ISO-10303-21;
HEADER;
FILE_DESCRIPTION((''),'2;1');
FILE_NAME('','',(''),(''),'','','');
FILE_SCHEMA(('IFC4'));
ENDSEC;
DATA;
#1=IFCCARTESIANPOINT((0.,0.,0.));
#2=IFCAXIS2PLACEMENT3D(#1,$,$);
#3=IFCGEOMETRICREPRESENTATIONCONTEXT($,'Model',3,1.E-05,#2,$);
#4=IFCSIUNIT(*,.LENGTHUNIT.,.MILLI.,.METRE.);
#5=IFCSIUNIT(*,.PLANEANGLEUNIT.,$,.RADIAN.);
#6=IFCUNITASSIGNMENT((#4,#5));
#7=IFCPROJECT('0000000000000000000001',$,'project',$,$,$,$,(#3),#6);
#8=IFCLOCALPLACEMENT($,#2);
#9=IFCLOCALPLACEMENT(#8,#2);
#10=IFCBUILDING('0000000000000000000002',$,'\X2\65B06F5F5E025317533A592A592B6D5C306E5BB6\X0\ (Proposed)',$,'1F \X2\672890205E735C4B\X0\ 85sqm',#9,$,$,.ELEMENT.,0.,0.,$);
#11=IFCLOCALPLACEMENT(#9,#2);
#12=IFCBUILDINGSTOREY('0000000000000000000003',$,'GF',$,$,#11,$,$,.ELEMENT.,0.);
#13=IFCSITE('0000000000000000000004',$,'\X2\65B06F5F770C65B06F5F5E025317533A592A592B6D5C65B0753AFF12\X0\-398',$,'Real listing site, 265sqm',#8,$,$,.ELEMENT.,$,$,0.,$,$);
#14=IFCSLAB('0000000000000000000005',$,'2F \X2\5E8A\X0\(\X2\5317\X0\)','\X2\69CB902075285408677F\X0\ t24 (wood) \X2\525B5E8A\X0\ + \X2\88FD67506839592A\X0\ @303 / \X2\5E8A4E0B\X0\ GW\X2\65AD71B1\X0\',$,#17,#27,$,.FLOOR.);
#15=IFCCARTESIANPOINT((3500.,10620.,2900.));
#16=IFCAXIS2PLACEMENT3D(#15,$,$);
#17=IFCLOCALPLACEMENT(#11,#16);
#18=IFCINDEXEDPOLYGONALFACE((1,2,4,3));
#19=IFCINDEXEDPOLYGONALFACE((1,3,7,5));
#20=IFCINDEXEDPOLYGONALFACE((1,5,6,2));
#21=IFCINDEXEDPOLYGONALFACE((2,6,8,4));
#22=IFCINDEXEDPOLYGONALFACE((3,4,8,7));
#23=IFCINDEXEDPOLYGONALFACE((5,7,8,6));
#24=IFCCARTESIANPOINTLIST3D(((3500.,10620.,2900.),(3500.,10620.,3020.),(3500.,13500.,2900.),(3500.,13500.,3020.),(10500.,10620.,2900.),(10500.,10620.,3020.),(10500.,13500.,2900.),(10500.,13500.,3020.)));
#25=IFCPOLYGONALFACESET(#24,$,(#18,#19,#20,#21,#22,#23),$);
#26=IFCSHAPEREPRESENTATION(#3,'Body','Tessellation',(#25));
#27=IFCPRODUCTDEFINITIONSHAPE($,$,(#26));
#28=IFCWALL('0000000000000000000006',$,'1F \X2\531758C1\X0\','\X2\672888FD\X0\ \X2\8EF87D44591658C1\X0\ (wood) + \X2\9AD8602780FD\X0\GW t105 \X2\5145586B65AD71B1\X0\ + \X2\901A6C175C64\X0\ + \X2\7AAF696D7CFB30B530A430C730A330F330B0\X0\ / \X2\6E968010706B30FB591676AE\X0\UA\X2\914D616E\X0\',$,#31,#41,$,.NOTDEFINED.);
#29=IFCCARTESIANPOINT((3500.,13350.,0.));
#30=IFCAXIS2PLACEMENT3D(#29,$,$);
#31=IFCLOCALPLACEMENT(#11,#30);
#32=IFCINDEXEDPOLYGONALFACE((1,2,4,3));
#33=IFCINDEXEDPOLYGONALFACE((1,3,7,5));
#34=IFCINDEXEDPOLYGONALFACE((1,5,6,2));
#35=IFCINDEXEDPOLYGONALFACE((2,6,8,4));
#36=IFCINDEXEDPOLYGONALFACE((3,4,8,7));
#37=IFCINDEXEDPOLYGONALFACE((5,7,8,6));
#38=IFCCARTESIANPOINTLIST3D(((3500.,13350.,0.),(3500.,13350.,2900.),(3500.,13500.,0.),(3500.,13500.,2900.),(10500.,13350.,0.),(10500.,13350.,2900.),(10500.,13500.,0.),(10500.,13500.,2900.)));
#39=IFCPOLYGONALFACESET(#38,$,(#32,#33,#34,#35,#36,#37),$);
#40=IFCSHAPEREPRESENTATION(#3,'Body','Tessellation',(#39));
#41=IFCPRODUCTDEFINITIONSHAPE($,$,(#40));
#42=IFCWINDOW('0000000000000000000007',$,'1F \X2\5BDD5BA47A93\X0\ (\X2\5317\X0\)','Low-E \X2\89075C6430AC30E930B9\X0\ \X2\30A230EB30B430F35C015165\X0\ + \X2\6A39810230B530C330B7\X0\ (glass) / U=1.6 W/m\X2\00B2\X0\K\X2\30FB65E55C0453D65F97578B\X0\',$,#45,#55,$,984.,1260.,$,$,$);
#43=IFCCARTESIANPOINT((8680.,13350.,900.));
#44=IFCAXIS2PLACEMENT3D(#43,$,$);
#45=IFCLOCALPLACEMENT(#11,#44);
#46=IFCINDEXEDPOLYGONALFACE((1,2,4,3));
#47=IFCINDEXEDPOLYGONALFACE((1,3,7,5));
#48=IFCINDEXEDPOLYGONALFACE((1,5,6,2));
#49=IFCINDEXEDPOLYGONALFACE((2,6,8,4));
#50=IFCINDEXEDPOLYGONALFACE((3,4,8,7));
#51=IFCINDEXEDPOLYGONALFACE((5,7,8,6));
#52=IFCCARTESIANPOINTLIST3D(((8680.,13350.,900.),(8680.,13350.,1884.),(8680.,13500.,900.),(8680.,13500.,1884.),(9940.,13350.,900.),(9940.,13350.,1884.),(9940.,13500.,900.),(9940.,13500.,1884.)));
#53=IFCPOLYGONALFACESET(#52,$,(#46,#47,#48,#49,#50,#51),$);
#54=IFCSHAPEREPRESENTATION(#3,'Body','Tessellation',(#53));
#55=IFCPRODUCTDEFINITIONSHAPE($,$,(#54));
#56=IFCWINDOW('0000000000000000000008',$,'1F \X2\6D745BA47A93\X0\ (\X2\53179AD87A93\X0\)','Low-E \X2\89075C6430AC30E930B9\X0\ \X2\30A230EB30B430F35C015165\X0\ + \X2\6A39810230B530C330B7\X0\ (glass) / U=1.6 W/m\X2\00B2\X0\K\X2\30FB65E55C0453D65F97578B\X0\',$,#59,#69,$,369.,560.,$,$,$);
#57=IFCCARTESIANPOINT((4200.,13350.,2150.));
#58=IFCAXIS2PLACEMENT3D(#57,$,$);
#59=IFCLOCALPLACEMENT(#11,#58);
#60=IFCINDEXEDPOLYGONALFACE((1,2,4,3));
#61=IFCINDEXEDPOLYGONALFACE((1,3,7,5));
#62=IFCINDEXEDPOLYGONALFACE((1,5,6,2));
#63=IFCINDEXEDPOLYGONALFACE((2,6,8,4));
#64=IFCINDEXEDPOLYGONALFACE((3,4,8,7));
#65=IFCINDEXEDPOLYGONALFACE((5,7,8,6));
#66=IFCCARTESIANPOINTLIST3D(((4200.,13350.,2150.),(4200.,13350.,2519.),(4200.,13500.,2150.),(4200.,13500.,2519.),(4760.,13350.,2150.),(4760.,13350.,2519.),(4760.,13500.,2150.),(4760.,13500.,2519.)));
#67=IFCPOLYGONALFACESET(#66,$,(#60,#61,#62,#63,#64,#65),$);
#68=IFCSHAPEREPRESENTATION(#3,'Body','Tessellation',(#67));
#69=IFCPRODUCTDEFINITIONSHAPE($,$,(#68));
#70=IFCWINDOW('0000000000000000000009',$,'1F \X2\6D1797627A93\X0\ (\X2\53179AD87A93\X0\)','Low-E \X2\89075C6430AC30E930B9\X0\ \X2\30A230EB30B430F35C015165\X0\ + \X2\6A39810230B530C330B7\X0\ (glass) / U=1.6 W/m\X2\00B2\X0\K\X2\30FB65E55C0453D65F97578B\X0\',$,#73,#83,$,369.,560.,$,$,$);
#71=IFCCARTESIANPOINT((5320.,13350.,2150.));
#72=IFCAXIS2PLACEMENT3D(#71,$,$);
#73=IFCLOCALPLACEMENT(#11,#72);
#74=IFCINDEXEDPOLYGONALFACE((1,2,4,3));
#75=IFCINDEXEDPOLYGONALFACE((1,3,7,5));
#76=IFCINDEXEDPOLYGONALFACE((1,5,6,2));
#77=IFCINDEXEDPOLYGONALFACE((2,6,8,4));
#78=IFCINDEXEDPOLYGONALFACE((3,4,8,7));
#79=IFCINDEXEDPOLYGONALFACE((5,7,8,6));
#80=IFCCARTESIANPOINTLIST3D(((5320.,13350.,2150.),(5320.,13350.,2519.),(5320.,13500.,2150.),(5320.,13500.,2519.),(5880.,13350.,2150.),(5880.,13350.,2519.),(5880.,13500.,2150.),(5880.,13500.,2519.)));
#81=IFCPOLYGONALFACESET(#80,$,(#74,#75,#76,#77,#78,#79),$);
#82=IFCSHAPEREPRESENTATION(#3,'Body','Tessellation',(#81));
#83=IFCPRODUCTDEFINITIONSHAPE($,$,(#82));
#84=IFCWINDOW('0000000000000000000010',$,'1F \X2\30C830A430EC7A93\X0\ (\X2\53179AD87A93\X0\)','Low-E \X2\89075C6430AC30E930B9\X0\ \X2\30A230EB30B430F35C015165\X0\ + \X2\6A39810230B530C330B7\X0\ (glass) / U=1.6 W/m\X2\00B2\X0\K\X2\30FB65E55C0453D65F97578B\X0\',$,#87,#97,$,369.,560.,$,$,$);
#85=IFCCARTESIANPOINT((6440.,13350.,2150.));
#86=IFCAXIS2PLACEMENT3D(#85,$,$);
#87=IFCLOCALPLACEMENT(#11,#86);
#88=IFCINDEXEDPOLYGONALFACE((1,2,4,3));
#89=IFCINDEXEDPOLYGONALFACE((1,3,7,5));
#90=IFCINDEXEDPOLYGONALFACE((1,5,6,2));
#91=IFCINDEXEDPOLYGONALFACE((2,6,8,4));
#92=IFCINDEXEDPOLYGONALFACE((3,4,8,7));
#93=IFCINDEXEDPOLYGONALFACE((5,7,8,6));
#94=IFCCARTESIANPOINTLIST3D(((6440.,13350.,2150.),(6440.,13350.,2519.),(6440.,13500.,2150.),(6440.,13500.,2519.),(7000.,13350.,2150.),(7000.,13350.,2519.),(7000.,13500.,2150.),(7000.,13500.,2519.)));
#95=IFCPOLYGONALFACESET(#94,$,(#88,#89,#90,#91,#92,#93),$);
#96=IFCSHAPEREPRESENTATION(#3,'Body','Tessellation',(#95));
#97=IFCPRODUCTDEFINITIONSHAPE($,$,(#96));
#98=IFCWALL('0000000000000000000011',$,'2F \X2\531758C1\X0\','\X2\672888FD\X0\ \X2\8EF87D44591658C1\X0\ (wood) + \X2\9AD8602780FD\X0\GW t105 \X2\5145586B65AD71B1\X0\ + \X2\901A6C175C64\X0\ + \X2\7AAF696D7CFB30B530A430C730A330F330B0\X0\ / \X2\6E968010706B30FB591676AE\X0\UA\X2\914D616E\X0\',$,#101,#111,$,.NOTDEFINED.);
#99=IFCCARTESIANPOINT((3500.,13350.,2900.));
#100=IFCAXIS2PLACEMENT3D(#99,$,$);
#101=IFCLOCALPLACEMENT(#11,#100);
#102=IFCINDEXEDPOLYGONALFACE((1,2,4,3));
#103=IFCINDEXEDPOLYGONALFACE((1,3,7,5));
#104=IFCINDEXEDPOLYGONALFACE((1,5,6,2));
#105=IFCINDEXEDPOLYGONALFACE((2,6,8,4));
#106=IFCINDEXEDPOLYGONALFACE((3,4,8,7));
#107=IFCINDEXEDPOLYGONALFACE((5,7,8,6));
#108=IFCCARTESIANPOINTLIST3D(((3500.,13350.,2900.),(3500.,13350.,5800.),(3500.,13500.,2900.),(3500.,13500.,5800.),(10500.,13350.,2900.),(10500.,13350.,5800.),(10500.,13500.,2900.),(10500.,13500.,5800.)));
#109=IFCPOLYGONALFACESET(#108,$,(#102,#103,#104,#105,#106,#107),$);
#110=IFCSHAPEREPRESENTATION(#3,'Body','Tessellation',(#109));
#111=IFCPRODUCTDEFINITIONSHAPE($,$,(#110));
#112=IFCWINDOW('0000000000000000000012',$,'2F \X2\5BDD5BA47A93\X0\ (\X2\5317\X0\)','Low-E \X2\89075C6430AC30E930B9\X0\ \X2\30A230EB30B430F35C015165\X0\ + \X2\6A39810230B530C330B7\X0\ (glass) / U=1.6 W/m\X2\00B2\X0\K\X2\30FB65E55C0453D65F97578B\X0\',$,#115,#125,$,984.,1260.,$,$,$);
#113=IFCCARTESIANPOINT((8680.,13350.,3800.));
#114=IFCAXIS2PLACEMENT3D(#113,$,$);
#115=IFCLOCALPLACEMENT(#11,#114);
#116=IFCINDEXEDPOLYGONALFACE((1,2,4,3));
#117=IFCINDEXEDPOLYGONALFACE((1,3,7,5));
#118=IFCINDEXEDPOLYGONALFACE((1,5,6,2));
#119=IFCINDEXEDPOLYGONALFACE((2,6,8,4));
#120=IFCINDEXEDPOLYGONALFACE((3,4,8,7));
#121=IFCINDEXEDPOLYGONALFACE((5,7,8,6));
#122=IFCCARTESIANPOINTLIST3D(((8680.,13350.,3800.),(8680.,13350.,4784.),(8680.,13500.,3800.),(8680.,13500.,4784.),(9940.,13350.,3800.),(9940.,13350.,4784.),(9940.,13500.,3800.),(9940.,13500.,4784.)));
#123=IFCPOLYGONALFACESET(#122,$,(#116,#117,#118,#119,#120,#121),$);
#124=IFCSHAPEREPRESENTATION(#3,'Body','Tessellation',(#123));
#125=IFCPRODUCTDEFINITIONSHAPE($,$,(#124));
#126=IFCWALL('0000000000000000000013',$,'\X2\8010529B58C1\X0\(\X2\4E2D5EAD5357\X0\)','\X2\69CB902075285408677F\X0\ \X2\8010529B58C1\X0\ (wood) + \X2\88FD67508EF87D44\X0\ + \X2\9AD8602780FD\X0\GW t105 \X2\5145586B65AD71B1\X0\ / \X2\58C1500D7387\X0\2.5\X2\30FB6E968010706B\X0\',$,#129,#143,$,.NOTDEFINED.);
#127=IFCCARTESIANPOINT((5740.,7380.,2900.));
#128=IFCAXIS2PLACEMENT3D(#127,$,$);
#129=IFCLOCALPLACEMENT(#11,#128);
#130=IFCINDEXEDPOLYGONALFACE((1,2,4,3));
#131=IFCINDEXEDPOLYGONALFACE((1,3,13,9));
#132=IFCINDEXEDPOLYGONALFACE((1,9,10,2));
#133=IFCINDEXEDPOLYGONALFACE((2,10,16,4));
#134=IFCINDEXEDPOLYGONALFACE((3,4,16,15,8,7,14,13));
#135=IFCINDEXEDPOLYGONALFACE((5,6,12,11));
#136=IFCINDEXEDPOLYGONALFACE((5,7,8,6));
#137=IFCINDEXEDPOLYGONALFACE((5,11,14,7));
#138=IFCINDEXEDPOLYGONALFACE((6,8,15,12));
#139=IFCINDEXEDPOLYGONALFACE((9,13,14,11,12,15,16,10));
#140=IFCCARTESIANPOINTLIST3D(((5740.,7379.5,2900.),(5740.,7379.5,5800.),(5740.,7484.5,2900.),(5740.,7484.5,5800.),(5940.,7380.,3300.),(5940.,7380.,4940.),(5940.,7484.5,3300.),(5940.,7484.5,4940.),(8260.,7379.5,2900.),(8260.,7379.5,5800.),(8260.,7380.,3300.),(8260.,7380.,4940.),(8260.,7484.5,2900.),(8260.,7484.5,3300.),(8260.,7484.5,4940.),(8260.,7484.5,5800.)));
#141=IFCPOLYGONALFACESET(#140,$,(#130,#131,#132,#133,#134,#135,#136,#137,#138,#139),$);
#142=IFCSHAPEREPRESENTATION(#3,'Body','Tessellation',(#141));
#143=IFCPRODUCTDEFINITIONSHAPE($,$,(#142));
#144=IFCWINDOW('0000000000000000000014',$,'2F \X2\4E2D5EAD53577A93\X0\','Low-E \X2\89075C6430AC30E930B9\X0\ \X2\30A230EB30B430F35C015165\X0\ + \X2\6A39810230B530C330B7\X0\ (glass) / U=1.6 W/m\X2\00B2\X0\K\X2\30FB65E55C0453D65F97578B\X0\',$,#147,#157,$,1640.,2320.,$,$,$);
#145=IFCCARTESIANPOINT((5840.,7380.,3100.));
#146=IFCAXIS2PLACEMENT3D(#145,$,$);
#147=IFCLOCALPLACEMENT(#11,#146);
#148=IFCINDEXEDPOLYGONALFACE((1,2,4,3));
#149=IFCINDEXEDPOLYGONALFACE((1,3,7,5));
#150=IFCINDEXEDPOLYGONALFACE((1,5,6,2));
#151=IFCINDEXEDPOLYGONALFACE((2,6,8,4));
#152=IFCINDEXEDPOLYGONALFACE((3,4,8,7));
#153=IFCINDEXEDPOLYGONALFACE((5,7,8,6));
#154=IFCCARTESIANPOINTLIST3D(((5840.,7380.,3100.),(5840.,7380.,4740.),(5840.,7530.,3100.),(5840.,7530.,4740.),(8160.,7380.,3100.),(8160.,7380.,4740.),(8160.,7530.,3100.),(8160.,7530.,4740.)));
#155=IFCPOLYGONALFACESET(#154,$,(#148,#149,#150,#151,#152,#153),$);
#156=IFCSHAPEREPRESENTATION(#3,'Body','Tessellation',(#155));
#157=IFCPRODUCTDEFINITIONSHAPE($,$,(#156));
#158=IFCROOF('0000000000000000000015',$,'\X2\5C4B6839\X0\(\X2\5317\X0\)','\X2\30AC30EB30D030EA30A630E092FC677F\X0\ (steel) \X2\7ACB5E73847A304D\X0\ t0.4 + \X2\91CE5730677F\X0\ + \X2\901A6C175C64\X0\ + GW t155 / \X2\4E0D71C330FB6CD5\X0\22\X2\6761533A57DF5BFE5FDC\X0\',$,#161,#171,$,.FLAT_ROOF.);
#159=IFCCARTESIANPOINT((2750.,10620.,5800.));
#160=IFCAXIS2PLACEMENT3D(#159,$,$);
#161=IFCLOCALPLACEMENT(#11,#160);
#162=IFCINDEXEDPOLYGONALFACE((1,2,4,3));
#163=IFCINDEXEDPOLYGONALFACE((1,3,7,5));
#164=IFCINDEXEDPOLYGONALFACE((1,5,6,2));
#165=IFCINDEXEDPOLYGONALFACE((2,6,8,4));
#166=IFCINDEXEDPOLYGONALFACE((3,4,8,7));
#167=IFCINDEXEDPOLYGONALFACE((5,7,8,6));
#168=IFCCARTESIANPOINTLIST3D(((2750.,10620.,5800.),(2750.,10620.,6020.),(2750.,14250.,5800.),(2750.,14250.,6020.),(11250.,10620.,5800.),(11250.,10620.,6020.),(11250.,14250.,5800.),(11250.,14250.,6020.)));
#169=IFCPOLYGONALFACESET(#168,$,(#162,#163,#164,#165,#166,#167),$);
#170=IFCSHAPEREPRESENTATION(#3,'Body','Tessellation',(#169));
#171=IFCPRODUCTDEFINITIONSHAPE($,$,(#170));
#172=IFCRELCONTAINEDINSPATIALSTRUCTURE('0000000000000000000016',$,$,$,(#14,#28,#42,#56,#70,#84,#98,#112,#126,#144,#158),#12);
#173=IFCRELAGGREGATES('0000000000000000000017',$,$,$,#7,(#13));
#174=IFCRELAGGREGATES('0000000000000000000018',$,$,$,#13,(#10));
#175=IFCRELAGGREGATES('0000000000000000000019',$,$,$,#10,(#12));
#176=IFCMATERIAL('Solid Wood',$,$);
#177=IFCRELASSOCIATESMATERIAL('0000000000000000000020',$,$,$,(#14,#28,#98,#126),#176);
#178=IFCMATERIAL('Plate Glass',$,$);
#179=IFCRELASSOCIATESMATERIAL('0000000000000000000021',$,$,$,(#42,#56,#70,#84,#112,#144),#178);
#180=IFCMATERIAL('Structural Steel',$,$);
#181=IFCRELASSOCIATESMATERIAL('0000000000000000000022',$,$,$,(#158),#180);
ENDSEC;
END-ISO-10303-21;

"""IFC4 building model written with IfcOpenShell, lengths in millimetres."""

from ifc_helpers import new_model, si_unit, frame, frame_2d, origin, place, context, project, spatial, rectangle, extrude, material, element, fill, save


model = new_model("IFC4")

# Units and contexts
model_context = context("Model", 3, precision=1e-05, world=origin())
ifc_project = project(units=[si_unit("LENGTHUNIT", "METRE", prefix="MILLI"), si_unit("PLANEANGLEUNIT", "RADIAN")], contexts=[model_context])

# Site, building, storey
site_placement = place(None, origin())
site = spatial("IfcSite", under=ifc_project, at=site_placement, Name="新潟県新潟市北区太夫浜新町２-398", ObjectType="Real listing site, 265sqm", CompositionType="ELEMENT", RefElevation=0.0)
building_placement = place(site_placement, origin())
building = spatial("IfcBuilding", under=site, at=building_placement, Name="新潟市北区太夫浜の家 (Proposed)", ObjectType="1F 木造平屋 85sqm", CompositionType="ELEMENT", ElevationOfRefHeight=0.0, ElevationOfTerrain=0.0)
storey_placement = place(building_placement, origin())
storey = spatial("IfcBuildingStorey", under=building, at=storey_placement, Name="GF", CompositionType="ELEMENT", Elevation=0.0)

# Slab
ifc_material_1 = material(Name="Solid Wood")
slab_1_placement = place(storey_placement, frame((3500.0, 10620.0, 2900.0)))
element("IfcSlab", 1, at=slab_1_placement, inside=storey, material=ifc_material_1, Name="2F 床(北)", Description="構造用合板 t24 (wood) 剛床 + 製材根太 @303 / 床下 GW断熱", PredefinedType="FLOOR", context=model_context, shape_type="SweptSolid", body=[
    extrude(rectangle(XDim=7000.0, YDim=2880.0, at=frame_2d((3500.0, 1440.0))), frame((3500.0, 10620.0, 2900.0)), (0.0, 0.0, 1.0), 120.0),
])

# Wall, openings, windows
wall_1_placement = place(storey_placement, frame((3500.0, 13350.0, 0.0)))
wall_1 = element("IfcWall", 2, at=wall_1_placement, inside=storey, material=ifc_material_1, Name="1F 北壁", Description="木製 軸組外壁 (wood) + 高性能GW t105 充填断熱 + 通気層 + 窯業系サイディング / 準耐火・外皮UA配慮", PredefinedType="NOTDEFINED", context=model_context, shape_type="SweptSolid", body=[
    extrude(rectangle(XDim=7000.0, YDim=150.0, at=frame_2d((3500.0, 75.0))), frame((3500.0, 13350.0, 0.0)), (0.0, 0.0, 1.0), 2900.0),
])
opening_1_placement = place(storey_placement, frame((8680.0, 13350.0, 900.0)))
opening_1 = element("IfcOpeningElement", 3, at=opening_1_placement, cuts=wall_1, PredefinedType="NOTDEFINED", context=model_context, shape_type="SweptSolid", body=[
    extrude(rectangle(XDim=1260.0, YDim=150.0, at=frame_2d((630.0, 75.0))), frame((8680.0, 13350.0, 900.0)), (0.0, 0.0, 1.0), 984.0),
])
opening_2_placement = place(storey_placement, frame((4200.0, 13350.0, 2150.0)))
opening_2 = element("IfcOpeningElement", 4, at=opening_2_placement, cuts=wall_1, PredefinedType="NOTDEFINED", context=model_context, shape_type="SweptSolid", body=[
    extrude(rectangle(XDim=560.0, YDim=150.0, at=frame_2d((280.0, 75.0))), frame((4200.0, 13350.0, 2150.0)), (0.0, 0.0, 1.0), 369.0),
])
opening_3_placement = place(storey_placement, frame((5320.0, 13350.0, 2150.0)))
opening_3 = element("IfcOpeningElement", 5, at=opening_3_placement, cuts=wall_1, PredefinedType="NOTDEFINED", context=model_context, shape_type="SweptSolid", body=[
    extrude(rectangle(XDim=560.0, YDim=150.0, at=frame_2d((280.0, 75.0))), frame((5320.0, 13350.0, 2150.0)), (0.0, 0.0, 1.0), 369.0),
])
opening_4_placement = place(storey_placement, frame((6440.0, 13350.0, 2150.0)))
opening_4 = element("IfcOpeningElement", 6, at=opening_4_placement, cuts=wall_1, PredefinedType="NOTDEFINED", context=model_context, shape_type="SweptSolid", body=[
    extrude(rectangle(XDim=560.0, YDim=150.0, at=frame_2d((280.0, 75.0))), frame((6440.0, 13350.0, 2150.0)), (0.0, 0.0, 1.0), 369.0),
])
ifc_material_2 = material(Name="Plate Glass")
window_1_placement = place(storey_placement, frame((8680.0, 13350.0, 900.0)))
window_1 = element("IfcWindow", 7, at=window_1_placement, inside=storey, material=ifc_material_2, Name="1F 寝室窓 (北)", Description="Low-E 複層ガラス アルゴン封入 + 樹脂サッシ (glass) / U=1.6 W/m²K・日射取得型", OverallHeight=984.0, OverallWidth=1260.0, context=model_context, shape_type="SweptSolid", body=[
    extrude(rectangle(XDim=1260.0, YDim=150.0, at=frame_2d((630.0, 75.0))), frame((8680.0, 13350.0, 900.0)), (0.0, 0.0, 1.0), 984.0),
])
fill(opening_1, window_1)
window_2_placement = place(storey_placement, frame((4200.0, 13350.0, 2150.0)))
window_2 = element("IfcWindow", 8, at=window_2_placement, inside=storey, material=ifc_material_2, Name="1F 浴室窓 (北高窓)", Description="Low-E 複層ガラス アルゴン封入 + 樹脂サッシ (glass) / U=1.6 W/m²K・日射取得型", OverallHeight=369.0, OverallWidth=560.0, context=model_context, shape_type="SweptSolid", body=[
    extrude(rectangle(XDim=560.0, YDim=150.0, at=frame_2d((280.0, 75.0))), frame((4200.0, 13350.0, 2150.0)), (0.0, 0.0, 1.0), 369.0),
])
fill(opening_2, window_2)
window_3_placement = place(storey_placement, frame((5320.0, 13350.0, 2150.0)))
window_3 = element("IfcWindow", 9, at=window_3_placement, inside=storey, material=ifc_material_2, Name="1F 洗面窓 (北高窓)", Description="Low-E 複層ガラス アルゴン封入 + 樹脂サッシ (glass) / U=1.6 W/m²K・日射取得型", OverallHeight=369.0, OverallWidth=560.0, context=model_context, shape_type="SweptSolid", body=[
    extrude(rectangle(XDim=560.0, YDim=150.0, at=frame_2d((280.0, 75.0))), frame((5320.0, 13350.0, 2150.0)), (0.0, 0.0, 1.0), 369.0),
])
fill(opening_3, window_3)
window_4_placement = place(storey_placement, frame((6440.0, 13350.0, 2150.0)))
window_4 = element("IfcWindow", 10, at=window_4_placement, inside=storey, material=ifc_material_2, Name="1F トイレ窓 (北高窓)", Description="Low-E 複層ガラス アルゴン封入 + 樹脂サッシ (glass) / U=1.6 W/m²K・日射取得型", OverallHeight=369.0, OverallWidth=560.0, context=model_context, shape_type="SweptSolid", body=[
    extrude(rectangle(XDim=560.0, YDim=150.0, at=frame_2d((280.0, 75.0))), frame((6440.0, 13350.0, 2150.0)), (0.0, 0.0, 1.0), 369.0),
])
fill(opening_4, window_4)

# Walls, openings, windows
wall_2_placement = place(storey_placement, frame((3500.0, 13350.0, 2900.0)))
wall_2 = element("IfcWall", 11, at=wall_2_placement, inside=storey, material=ifc_material_1, Name="2F 北壁", Description="木製 軸組外壁 (wood) + 高性能GW t105 充填断熱 + 通気層 + 窯業系サイディング / 準耐火・外皮UA配慮", PredefinedType="NOTDEFINED", context=model_context, shape_type="SweptSolid", body=[
    extrude(rectangle(XDim=7000.0, YDim=150.0, at=frame_2d((3500.0, 75.0))), frame((3500.0, 13350.0, 2900.0)), (0.0, 0.0, 1.0), 2900.0),
])
opening_5_placement = place(storey_placement, frame((8680.0, 13350.0, 3800.0)))
opening_5 = element("IfcOpeningElement", 12, at=opening_5_placement, cuts=wall_2, PredefinedType="NOTDEFINED", context=model_context, shape_type="SweptSolid", body=[
    extrude(rectangle(XDim=1260.0, YDim=150.0, at=frame_2d((630.0, 75.0))), frame((8680.0, 13350.0, 3800.0)), (0.0, 0.0, 1.0), 984.0),
])
window_5_placement = place(storey_placement, frame((8680.0, 13350.0, 3800.0)))
window_5 = element("IfcWindow", 13, at=window_5_placement, inside=storey, material=ifc_material_2, Name="2F 寝室窓 (北)", Description="Low-E 複層ガラス アルゴン封入 + 樹脂サッシ (glass) / U=1.6 W/m²K・日射取得型", OverallHeight=984.0, OverallWidth=1260.0, context=model_context, shape_type="SweptSolid", body=[
    extrude(rectangle(XDim=1260.0, YDim=150.0, at=frame_2d((630.0, 75.0))), frame((8680.0, 13350.0, 3800.0)), (0.0, 0.0, 1.0), 984.0),
])
fill(opening_5, window_5)
wall_3_placement = place(storey_placement, frame((5740.0, 7380.0, 2900.0)))
wall_3 = element("IfcWall", 14, at=wall_3_placement, inside=storey, material=ifc_material_1, Name="耐力壁(中庭南)", Description="構造用合板 耐力壁 (wood) + 製材軸組 + 高性能GW t105 充填断熱 / 壁倍率2.5・準耐火", PredefinedType="NOTDEFINED", context=model_context, shape_type="SweptSolid", body=[
    extrude(rectangle(XDim=2520.0, YDim=105.0, at=frame_2d((1260.0, 52.0))), frame((5740.0, 7380.0, 2900.0)), (0.0, 0.0, 1.0), 2900.0),
])
opening_6_placement = place(storey_placement, frame((5840.0, 7380.0, 3100.0)))
opening_6 = element("IfcOpeningElement", 15, at=opening_6_placement, cuts=wall_3, PredefinedType="NOTDEFINED", context=model_context, shape_type="SweptSolid", body=[
    extrude(rectangle(XDim=2320.0, YDim=150.0, at=frame_2d((1160.0, 75.0))), frame((5840.0, 7380.0, 3100.0)), (0.0, 0.0, 1.0), 1640.0),
])
window_6_placement = place(storey_placement, frame((5840.0, 7380.0, 3100.0)))
window_6 = element("IfcWindow", 16, at=window_6_placement, inside=storey, material=ifc_material_2, Name="2F 中庭南窓", Description="Low-E 複層ガラス アルゴン封入 + 樹脂サッシ (glass) / U=1.6 W/m²K・日射取得型", OverallHeight=1640.0, OverallWidth=2320.0, context=model_context, shape_type="SweptSolid", body=[
    extrude(rectangle(XDim=2320.0, YDim=150.0, at=frame_2d((1160.0, 75.0))), frame((5840.0, 7380.0, 3100.0)), (0.0, 0.0, 1.0), 1640.0),
])
fill(opening_6, window_6)

# Roof
ifc_material_3 = material(Name="Structural Steel")
for number, where, name in (
    (17, (2750.0, 10620.0, 5800.0), "屋根(北)"),
):
    element("IfcRoof", number, at=place(storey_placement, frame(where)), inside=storey, material=ifc_material_3, Name=name, Description="ガルバリウム鋼板 (steel) 立平葺き t0.4 + 野地板 + 通気層 + GW t155 / 不燃・法22条区域対応", PredefinedType="FLAT_ROOF", context=model_context, shape_type="SweptSolid", body=[
        extrude(rectangle(XDim=8500.0, YDim=3630.0, at=frame_2d((4250.0, 1815.0))), frame((2750.0, 10620.0, 5800.0)), (0.0, 0.0, 1.0), 220.0),
    ])

save(model, "model.ifc")
